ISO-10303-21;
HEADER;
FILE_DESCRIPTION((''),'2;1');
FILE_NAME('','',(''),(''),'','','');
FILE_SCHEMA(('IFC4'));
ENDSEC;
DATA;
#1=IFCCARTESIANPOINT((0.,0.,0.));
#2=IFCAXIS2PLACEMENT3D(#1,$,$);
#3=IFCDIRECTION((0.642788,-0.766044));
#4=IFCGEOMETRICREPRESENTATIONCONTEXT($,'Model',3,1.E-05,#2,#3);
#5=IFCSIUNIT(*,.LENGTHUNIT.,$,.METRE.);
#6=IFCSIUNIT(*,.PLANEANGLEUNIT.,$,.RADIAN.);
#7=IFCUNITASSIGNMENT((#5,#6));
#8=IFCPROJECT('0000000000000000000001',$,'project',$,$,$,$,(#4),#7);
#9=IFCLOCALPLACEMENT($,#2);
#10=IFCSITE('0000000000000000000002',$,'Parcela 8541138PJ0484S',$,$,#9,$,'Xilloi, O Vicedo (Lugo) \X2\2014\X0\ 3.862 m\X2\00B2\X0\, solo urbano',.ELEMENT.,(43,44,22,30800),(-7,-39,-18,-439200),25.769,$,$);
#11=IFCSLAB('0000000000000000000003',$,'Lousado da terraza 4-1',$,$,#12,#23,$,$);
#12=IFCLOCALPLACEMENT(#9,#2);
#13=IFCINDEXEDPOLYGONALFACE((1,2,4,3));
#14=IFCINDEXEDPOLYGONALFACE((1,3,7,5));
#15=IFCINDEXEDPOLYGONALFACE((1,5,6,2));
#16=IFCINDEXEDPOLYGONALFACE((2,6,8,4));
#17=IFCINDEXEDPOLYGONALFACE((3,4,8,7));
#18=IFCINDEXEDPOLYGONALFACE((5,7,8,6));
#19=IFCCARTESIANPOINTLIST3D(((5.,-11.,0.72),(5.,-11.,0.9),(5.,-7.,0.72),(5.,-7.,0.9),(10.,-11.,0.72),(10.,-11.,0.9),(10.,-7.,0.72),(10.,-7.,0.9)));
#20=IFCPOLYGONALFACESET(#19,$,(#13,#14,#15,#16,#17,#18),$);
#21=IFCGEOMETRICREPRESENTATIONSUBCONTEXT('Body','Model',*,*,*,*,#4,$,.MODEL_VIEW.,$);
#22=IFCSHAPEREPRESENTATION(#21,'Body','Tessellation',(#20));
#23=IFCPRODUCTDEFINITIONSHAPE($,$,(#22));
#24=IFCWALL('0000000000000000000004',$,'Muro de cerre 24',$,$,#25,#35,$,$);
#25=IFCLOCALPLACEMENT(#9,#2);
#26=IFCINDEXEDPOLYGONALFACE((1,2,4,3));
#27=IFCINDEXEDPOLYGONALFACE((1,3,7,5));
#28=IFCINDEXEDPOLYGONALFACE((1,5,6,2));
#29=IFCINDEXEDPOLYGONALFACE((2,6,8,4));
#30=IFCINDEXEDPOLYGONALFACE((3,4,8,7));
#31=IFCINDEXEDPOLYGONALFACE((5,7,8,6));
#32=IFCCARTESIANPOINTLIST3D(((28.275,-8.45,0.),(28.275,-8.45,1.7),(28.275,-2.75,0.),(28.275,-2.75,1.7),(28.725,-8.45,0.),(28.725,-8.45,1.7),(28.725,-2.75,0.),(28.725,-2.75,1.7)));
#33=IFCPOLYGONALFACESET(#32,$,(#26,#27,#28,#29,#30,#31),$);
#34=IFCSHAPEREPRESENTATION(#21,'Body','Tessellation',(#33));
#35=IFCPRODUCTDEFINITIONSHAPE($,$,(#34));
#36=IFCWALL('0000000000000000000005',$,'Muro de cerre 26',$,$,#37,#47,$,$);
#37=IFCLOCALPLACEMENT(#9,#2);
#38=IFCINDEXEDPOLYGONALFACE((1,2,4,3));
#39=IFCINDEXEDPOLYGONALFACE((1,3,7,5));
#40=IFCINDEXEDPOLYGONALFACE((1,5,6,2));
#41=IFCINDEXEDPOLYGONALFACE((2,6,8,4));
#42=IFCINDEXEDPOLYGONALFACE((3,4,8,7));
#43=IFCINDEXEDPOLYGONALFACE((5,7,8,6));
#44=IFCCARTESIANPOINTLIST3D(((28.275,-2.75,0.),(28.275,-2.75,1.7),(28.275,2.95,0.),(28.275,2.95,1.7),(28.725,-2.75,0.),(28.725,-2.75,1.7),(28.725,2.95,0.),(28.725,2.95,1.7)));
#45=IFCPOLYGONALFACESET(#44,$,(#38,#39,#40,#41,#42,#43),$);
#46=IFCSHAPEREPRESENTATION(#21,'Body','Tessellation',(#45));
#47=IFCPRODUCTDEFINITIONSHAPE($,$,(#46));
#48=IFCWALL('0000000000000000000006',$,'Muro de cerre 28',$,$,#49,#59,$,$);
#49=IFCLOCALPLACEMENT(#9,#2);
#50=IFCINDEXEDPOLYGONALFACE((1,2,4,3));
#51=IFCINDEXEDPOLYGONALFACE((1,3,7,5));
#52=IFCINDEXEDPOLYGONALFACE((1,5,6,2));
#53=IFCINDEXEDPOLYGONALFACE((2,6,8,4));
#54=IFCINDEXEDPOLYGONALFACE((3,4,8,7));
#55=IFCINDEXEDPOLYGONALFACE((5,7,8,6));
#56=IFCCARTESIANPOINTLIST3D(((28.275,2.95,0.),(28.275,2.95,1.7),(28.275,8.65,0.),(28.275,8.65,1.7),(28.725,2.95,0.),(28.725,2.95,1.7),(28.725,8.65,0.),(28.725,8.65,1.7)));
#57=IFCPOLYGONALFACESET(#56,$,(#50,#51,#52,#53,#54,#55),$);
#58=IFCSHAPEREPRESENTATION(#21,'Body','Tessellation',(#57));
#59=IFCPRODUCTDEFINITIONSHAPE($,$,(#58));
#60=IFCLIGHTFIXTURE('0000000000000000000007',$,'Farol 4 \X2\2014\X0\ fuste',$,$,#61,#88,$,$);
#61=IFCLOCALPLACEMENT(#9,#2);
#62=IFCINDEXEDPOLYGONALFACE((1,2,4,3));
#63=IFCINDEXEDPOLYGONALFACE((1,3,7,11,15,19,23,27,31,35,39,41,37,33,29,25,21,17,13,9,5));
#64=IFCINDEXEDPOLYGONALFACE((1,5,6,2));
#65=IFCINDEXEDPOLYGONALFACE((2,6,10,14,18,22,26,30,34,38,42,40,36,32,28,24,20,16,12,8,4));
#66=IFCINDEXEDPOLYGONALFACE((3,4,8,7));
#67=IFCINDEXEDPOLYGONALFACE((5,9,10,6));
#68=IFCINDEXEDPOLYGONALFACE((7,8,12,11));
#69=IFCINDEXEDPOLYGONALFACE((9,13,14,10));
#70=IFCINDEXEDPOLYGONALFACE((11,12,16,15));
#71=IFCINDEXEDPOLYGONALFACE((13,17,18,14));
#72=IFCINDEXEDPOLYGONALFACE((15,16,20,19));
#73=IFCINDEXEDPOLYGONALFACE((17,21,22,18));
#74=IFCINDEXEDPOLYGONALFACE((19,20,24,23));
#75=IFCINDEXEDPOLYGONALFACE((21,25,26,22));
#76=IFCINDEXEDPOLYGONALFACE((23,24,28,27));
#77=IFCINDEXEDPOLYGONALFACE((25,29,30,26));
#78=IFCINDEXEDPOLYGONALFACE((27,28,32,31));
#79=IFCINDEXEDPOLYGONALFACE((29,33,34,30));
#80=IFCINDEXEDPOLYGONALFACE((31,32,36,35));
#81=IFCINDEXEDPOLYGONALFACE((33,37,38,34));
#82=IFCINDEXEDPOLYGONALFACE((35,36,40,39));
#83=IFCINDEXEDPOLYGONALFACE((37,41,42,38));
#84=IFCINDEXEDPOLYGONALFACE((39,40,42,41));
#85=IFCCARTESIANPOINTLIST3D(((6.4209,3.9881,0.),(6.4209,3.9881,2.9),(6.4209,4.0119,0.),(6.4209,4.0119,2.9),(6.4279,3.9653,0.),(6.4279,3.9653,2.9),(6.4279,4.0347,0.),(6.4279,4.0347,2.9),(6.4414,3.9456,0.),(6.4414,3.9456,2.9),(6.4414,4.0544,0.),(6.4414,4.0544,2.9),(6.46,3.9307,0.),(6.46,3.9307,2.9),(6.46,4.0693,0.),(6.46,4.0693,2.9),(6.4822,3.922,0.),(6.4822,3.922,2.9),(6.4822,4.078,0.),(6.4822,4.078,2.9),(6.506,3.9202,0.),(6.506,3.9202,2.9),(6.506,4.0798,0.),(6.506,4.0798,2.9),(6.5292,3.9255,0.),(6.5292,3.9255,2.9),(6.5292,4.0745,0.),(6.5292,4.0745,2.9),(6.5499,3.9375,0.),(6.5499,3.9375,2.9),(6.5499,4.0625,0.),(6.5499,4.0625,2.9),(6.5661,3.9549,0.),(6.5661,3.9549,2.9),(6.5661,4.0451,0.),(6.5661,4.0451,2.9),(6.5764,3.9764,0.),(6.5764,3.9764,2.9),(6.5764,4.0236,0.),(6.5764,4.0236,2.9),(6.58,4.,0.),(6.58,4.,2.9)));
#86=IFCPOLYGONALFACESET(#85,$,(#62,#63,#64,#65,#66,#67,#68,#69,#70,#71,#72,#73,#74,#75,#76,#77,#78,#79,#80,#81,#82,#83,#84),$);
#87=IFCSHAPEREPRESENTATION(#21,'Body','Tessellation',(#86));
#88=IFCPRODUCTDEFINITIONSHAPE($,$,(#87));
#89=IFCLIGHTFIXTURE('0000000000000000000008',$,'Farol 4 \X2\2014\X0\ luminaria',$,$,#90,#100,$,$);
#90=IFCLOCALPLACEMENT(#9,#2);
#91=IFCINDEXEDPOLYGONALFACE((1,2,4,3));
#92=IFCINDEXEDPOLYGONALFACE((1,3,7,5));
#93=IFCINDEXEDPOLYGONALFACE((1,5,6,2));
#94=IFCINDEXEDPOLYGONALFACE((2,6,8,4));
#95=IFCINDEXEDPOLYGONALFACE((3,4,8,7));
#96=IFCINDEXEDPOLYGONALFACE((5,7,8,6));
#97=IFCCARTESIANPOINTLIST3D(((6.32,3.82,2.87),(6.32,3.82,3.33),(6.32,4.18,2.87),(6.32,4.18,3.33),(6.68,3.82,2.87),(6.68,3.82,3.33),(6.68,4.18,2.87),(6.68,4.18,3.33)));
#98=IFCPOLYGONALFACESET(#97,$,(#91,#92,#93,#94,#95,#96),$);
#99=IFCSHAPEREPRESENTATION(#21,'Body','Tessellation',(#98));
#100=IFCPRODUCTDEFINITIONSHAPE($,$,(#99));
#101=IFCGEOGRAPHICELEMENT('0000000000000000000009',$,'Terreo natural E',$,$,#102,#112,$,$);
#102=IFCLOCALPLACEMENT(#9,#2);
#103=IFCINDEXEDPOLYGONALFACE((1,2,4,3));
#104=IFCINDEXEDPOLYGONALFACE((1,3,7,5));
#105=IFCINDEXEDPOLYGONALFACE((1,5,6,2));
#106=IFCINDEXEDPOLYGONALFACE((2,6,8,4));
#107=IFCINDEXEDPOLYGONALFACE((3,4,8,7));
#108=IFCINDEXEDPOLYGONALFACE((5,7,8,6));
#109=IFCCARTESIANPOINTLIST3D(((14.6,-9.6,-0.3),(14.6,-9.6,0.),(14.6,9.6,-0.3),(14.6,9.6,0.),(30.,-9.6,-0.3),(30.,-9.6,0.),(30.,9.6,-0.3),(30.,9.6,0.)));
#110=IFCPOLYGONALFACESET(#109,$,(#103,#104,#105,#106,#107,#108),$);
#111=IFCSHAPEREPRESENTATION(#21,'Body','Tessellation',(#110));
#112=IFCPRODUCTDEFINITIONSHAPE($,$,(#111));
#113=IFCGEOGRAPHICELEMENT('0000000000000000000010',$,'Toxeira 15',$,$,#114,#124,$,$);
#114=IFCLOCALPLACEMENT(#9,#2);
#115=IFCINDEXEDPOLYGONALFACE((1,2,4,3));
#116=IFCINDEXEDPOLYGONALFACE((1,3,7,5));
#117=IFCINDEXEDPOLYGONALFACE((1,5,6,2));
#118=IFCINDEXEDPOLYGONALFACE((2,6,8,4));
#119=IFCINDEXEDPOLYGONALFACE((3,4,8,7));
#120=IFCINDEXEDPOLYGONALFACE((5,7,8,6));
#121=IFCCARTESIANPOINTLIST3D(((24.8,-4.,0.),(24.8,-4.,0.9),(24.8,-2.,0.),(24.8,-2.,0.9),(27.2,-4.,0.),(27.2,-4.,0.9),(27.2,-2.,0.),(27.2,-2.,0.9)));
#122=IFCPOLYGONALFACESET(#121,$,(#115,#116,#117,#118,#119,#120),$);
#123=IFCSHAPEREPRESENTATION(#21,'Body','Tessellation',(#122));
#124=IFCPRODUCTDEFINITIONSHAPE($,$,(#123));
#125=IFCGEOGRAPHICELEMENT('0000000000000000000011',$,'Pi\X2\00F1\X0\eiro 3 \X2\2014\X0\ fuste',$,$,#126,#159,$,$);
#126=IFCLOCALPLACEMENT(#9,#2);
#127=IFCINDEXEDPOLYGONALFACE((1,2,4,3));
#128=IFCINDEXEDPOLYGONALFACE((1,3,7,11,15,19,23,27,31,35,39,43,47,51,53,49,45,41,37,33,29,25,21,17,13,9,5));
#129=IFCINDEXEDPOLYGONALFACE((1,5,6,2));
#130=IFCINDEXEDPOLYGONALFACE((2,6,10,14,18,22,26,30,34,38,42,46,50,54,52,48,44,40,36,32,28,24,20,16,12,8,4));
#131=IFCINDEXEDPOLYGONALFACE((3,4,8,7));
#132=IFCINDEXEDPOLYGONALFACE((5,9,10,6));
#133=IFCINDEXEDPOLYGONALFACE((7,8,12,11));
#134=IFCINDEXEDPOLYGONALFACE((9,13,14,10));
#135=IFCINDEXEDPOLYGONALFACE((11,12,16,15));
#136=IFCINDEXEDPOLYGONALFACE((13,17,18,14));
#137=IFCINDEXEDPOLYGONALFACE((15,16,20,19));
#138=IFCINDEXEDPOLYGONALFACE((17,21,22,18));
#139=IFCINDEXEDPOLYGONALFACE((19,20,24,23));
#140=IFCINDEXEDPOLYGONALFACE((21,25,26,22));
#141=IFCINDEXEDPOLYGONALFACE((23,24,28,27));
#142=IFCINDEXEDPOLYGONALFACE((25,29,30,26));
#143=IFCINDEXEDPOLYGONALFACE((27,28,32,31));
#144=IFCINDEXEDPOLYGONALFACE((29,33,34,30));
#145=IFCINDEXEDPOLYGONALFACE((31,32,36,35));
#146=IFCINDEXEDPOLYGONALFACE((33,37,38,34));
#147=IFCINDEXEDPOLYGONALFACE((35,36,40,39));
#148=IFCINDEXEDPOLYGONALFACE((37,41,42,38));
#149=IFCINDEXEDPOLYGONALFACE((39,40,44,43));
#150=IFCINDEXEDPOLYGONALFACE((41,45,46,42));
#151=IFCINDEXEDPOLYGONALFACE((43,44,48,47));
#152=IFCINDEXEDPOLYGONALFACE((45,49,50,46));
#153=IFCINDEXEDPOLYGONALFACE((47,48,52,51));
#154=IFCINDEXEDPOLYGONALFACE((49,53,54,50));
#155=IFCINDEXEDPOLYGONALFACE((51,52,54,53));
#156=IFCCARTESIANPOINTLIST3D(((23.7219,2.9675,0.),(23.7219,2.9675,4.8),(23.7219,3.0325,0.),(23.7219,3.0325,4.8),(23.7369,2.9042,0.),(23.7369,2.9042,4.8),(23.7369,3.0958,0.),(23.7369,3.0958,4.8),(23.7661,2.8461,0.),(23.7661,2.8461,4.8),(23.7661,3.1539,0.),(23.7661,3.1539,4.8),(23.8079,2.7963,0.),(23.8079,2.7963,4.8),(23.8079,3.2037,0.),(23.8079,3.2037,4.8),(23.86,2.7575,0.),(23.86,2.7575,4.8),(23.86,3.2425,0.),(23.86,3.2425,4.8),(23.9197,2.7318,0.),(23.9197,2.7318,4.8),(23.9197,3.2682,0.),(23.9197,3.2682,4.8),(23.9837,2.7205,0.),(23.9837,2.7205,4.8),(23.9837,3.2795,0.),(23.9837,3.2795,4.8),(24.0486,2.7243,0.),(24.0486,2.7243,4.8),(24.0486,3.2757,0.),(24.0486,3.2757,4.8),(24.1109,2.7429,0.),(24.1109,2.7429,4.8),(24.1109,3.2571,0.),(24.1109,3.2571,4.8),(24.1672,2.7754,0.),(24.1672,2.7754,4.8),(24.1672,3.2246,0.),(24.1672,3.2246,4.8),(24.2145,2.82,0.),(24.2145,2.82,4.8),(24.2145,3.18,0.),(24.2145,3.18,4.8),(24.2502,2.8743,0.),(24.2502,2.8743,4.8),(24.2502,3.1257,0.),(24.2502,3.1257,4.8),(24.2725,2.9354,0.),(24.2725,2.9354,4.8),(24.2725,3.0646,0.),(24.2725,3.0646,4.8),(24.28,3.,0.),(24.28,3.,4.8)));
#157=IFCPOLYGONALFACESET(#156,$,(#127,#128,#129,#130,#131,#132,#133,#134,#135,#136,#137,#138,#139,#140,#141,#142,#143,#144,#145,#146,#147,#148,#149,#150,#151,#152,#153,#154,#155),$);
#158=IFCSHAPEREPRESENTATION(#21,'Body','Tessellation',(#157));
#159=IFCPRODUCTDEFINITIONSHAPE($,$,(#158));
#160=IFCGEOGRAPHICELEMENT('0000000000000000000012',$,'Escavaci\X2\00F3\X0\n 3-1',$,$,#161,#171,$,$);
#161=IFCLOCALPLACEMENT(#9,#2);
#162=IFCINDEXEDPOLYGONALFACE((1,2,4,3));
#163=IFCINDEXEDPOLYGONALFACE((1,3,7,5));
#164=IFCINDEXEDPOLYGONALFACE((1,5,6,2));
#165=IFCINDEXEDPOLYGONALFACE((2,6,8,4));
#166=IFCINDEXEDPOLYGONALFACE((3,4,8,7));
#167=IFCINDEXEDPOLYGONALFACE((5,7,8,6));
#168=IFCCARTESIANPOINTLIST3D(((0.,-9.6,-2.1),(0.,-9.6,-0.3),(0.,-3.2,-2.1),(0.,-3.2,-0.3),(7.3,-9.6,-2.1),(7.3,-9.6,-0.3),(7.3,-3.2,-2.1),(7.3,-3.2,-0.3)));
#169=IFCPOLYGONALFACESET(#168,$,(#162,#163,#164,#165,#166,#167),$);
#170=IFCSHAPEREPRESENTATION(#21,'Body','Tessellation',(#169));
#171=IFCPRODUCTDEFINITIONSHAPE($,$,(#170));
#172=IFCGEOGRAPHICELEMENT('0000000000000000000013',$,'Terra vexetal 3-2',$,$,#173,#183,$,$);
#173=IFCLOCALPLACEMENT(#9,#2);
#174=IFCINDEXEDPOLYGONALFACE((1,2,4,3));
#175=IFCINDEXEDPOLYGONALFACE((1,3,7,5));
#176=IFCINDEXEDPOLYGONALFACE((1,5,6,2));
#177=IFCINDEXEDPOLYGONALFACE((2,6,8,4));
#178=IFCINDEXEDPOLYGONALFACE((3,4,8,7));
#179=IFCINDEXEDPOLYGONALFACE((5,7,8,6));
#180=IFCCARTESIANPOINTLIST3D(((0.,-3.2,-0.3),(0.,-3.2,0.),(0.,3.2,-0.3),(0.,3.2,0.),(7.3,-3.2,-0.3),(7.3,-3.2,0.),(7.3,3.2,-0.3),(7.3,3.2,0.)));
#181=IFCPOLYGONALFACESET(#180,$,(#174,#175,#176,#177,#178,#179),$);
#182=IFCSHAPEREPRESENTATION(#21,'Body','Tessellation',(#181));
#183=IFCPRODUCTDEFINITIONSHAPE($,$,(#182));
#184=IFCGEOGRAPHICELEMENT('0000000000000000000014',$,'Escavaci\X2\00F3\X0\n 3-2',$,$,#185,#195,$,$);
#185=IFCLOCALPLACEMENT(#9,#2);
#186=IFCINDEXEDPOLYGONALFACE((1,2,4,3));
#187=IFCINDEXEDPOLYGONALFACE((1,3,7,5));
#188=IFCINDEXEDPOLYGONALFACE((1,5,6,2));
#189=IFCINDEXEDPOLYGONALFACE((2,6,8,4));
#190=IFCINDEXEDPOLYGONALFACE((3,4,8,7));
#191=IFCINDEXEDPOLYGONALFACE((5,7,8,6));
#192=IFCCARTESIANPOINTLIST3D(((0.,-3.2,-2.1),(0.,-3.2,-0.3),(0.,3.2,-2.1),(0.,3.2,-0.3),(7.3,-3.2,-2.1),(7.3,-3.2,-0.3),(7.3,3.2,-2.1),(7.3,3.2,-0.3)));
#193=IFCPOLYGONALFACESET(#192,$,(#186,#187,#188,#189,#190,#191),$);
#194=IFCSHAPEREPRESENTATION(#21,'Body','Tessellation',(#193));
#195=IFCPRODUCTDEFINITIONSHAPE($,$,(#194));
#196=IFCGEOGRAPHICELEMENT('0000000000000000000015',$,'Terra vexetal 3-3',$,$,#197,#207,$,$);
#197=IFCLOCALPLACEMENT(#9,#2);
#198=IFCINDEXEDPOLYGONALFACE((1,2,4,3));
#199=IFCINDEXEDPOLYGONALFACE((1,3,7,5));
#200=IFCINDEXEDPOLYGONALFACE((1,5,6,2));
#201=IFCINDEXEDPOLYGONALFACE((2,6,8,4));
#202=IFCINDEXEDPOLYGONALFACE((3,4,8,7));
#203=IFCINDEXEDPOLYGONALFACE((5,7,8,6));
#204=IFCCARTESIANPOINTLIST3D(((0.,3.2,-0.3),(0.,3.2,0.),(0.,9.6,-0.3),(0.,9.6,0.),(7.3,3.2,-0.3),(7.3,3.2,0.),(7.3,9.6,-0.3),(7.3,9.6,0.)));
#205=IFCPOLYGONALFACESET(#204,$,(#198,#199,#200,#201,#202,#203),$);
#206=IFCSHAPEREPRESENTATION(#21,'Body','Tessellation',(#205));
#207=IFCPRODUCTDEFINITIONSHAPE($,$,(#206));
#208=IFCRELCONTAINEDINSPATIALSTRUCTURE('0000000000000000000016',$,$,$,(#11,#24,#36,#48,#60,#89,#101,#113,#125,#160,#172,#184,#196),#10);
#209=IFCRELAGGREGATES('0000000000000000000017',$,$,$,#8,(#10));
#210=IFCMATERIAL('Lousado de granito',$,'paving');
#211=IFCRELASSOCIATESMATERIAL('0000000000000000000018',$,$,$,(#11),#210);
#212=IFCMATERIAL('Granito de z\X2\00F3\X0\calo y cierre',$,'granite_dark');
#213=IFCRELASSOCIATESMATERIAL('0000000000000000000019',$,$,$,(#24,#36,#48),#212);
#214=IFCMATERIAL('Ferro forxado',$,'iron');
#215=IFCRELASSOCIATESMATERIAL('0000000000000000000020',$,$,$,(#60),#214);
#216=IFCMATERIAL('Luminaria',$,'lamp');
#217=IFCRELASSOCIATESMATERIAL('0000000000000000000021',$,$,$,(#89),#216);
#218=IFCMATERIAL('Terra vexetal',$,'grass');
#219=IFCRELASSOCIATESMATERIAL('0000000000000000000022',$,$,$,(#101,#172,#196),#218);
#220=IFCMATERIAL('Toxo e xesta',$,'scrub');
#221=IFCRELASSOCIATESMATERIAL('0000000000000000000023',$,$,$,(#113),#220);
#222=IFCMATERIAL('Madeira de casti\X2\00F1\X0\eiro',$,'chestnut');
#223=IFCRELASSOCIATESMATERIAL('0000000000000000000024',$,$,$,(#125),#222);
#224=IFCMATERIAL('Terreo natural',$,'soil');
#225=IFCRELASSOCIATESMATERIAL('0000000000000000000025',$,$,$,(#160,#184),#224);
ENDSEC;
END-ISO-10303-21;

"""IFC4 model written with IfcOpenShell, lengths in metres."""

from ifc_helpers import new_model, si_unit, direction, frame, origin, origin_2d, place, context, subcontext, project, spatial, rectangle, circle, extrude, material, element, save


model = new_model("IFC4")

# Units and contexts
model_context = context("Model", 3, precision=1e-05, world=origin(), true_north=direction((0.642788, -0.766044)))
body_context = subcontext(model_context, "Body", "Model", "MODEL_VIEW")
ifc_project = project(units=[si_unit("LENGTHUNIT", "METRE"), si_unit("PLANEANGLEUNIT", "RADIAN")], contexts=[model_context])

# Site
site_placement = place(None, origin())
site = spatial("IfcSite", under=ifc_project, at=site_placement, Name="Parcela 8541138PJ0484S", LongName="Xilloi, O Vicedo (Lugo) — 3.862 m², solo urbano", CompositionType="ELEMENT", RefLatitude=(43, 44, 22, 30800), RefLongitude=(-7, -39, -18, -439200), RefElevation=25.769)

# Slab
ifc_material_1 = material(Name="Lousado de granito", Category="paving")
slab_placement = place(site_placement, frame((7.5, -9.0, 0.81)))
element("IfcSlab", 1, at=slab_placement, inside=site, material=ifc_material_1, Name="Lousado da terraza 4-1", context=body_context, shape_type="SweptSolid", body=[
    extrude(rectangle(XDim=5.0, YDim=4.0, at=origin_2d()), frame((0.0, 0.0, -0.09)), (0.0, 0.0, 1.0), 0.18),
])

# Walls
ifc_material_2 = material(Name="Granito de zócalo y cierre", Category="granite_dark")
for number, where, name in (
    (2, (28.5, -5.6, 0.85), "Muro de cerre 24"),
    (3, (28.5, 0.1, 0.85), "Muro de cerre 26"),
    (4, (28.5, 5.8, 0.85), "Muro de cerre 28"),
):
    element("IfcWall", number, at=place(site_placement, frame(where)), inside=site, material=ifc_material_2, Name=name, context=body_context, shape_type="SweptSolid", body=[
        extrude(rectangle(XDim=0.45, YDim=5.7, at=origin_2d()), frame((0.0, 0.0, -0.85)), (0.0, 0.0, 1.0), 1.7),
    ])

# Light fixtures
ifc_material_3 = material(Name="Ferro forxado", Category="iron")
light_fixture_1_placement = place(site_placement, frame((6.5, 4.0, 1.45)))
element("IfcLightFixture", 5, at=light_fixture_1_placement, inside=site, material=ifc_material_3, Name="Farol 4 — fuste", context=body_context, shape_type="SweptSolid", body=[
    extrude(circle(Radius=0.08, at=origin_2d()), frame((0.0, 0.0, -1.45)), (0.0, 0.0, 1.0), 2.9),
])
ifc_material_4 = material(Name="Luminaria", Category="lamp")
light_fixture_2_placement = place(site_placement, frame((6.5, 4.0, 3.1)))
element("IfcLightFixture", 6, at=light_fixture_2_placement, inside=site, material=ifc_material_4, Name="Farol 4 — luminaria", context=body_context, shape_type="SweptSolid", body=[
    extrude(rectangle(XDim=0.36, YDim=0.36, at=origin_2d()), frame((0.0, 0.0, -0.23)), (0.0, 0.0, 1.0), 0.46),
])

# Geographic elements
ifc_material_5 = material(Name="Terra vexetal", Category="grass")
geographic_element_1_placement = place(site_placement, frame((22.3, 0.0, -0.15)))
element("IfcGeographicElement", 7, at=geographic_element_1_placement, inside=site, material=ifc_material_5, Name="Terreo natural E", context=body_context, shape_type="SweptSolid", body=[
    extrude(rectangle(XDim=15.4, YDim=19.2, at=origin_2d()), frame((0.0, 0.0, -0.15)), (0.0, 0.0, 1.0), 0.3),
])
ifc_material_6 = material(Name="Toxo e xesta", Category="scrub")
geographic_element_2_placement = place(site_placement, frame((26.0, -3.0, 0.45)))
element("IfcGeographicElement", 8, at=geographic_element_2_placement, inside=site, material=ifc_material_6, Name="Toxeira 15", context=body_context, shape_type="SweptSolid", body=[
    extrude(rectangle(XDim=2.4, YDim=2.0, at=origin_2d()), frame((0.0, 0.0, -0.45)), (0.0, 0.0, 1.0), 0.9),
])
ifc_material_7 = material(Name="Madeira de castiñeiro", Category="chestnut")
geographic_element_3_placement = place(site_placement, frame((24.0, 3.0, 2.4)))
element("IfcGeographicElement", 9, at=geographic_element_3_placement, inside=site, material=ifc_material_7, Name="Piñeiro 3 — fuste", context=body_context, shape_type="SweptSolid", body=[
    extrude(circle(Radius=0.28, at=origin_2d()), frame((0.0, 0.0, -2.4)), (0.0, 0.0, 1.0), 4.8),
])
ifc_material_8 = material(Name="Terreo natural", Category="soil")
geographic_element_4_placement = place(site_placement, frame((3.65, -6.4, -1.2)))
element("IfcGeographicElement", 10, at=geographic_element_4_placement, inside=site, material=ifc_material_8, Name="Escavación 3-1", context=body_context, shape_type="SweptSolid", body=[
    extrude(rectangle(XDim=7.3, YDim=6.4, at=origin_2d()), frame((0.0, 0.0, -0.9)), (0.0, 0.0, 1.0), 1.8),
])
geographic_element_5_placement = place(site_placement, frame((3.65, 0.0, -0.15)))
element("IfcGeographicElement", 11, at=geographic_element_5_placement, inside=site, material=ifc_material_5, Name="Terra vexetal 3-2", context=body_context, shape_type="SweptSolid", body=[
    extrude(rectangle(XDim=7.3, YDim=6.4, at=origin_2d()), frame((0.0, 0.0, -0.15)), (0.0, 0.0, 1.0), 0.3),
])
geographic_element_6_placement = place(site_placement, frame((3.65, 0.0, -1.2)))
element("IfcGeographicElement", 12, at=geographic_element_6_placement, inside=site, material=ifc_material_8, Name="Escavación 3-2", context=body_context, shape_type="SweptSolid", body=[
    extrude(rectangle(XDim=7.3, YDim=6.4, at=origin_2d()), frame((0.0, 0.0, -0.9)), (0.0, 0.0, 1.0), 1.8),
])
geographic_element_7_placement = place(site_placement, frame((3.65, 6.4, -0.15)))
element("IfcGeographicElement", 13, at=geographic_element_7_placement, inside=site, material=ifc_material_5, Name="Terra vexetal 3-3", context=body_context, shape_type="SweptSolid", body=[
    extrude(rectangle(XDim=7.3, YDim=6.4, at=origin_2d()), frame((0.0, 0.0, -0.15)), (0.0, 0.0, 1.0), 0.3),
])

save(model, "model.ifc")
